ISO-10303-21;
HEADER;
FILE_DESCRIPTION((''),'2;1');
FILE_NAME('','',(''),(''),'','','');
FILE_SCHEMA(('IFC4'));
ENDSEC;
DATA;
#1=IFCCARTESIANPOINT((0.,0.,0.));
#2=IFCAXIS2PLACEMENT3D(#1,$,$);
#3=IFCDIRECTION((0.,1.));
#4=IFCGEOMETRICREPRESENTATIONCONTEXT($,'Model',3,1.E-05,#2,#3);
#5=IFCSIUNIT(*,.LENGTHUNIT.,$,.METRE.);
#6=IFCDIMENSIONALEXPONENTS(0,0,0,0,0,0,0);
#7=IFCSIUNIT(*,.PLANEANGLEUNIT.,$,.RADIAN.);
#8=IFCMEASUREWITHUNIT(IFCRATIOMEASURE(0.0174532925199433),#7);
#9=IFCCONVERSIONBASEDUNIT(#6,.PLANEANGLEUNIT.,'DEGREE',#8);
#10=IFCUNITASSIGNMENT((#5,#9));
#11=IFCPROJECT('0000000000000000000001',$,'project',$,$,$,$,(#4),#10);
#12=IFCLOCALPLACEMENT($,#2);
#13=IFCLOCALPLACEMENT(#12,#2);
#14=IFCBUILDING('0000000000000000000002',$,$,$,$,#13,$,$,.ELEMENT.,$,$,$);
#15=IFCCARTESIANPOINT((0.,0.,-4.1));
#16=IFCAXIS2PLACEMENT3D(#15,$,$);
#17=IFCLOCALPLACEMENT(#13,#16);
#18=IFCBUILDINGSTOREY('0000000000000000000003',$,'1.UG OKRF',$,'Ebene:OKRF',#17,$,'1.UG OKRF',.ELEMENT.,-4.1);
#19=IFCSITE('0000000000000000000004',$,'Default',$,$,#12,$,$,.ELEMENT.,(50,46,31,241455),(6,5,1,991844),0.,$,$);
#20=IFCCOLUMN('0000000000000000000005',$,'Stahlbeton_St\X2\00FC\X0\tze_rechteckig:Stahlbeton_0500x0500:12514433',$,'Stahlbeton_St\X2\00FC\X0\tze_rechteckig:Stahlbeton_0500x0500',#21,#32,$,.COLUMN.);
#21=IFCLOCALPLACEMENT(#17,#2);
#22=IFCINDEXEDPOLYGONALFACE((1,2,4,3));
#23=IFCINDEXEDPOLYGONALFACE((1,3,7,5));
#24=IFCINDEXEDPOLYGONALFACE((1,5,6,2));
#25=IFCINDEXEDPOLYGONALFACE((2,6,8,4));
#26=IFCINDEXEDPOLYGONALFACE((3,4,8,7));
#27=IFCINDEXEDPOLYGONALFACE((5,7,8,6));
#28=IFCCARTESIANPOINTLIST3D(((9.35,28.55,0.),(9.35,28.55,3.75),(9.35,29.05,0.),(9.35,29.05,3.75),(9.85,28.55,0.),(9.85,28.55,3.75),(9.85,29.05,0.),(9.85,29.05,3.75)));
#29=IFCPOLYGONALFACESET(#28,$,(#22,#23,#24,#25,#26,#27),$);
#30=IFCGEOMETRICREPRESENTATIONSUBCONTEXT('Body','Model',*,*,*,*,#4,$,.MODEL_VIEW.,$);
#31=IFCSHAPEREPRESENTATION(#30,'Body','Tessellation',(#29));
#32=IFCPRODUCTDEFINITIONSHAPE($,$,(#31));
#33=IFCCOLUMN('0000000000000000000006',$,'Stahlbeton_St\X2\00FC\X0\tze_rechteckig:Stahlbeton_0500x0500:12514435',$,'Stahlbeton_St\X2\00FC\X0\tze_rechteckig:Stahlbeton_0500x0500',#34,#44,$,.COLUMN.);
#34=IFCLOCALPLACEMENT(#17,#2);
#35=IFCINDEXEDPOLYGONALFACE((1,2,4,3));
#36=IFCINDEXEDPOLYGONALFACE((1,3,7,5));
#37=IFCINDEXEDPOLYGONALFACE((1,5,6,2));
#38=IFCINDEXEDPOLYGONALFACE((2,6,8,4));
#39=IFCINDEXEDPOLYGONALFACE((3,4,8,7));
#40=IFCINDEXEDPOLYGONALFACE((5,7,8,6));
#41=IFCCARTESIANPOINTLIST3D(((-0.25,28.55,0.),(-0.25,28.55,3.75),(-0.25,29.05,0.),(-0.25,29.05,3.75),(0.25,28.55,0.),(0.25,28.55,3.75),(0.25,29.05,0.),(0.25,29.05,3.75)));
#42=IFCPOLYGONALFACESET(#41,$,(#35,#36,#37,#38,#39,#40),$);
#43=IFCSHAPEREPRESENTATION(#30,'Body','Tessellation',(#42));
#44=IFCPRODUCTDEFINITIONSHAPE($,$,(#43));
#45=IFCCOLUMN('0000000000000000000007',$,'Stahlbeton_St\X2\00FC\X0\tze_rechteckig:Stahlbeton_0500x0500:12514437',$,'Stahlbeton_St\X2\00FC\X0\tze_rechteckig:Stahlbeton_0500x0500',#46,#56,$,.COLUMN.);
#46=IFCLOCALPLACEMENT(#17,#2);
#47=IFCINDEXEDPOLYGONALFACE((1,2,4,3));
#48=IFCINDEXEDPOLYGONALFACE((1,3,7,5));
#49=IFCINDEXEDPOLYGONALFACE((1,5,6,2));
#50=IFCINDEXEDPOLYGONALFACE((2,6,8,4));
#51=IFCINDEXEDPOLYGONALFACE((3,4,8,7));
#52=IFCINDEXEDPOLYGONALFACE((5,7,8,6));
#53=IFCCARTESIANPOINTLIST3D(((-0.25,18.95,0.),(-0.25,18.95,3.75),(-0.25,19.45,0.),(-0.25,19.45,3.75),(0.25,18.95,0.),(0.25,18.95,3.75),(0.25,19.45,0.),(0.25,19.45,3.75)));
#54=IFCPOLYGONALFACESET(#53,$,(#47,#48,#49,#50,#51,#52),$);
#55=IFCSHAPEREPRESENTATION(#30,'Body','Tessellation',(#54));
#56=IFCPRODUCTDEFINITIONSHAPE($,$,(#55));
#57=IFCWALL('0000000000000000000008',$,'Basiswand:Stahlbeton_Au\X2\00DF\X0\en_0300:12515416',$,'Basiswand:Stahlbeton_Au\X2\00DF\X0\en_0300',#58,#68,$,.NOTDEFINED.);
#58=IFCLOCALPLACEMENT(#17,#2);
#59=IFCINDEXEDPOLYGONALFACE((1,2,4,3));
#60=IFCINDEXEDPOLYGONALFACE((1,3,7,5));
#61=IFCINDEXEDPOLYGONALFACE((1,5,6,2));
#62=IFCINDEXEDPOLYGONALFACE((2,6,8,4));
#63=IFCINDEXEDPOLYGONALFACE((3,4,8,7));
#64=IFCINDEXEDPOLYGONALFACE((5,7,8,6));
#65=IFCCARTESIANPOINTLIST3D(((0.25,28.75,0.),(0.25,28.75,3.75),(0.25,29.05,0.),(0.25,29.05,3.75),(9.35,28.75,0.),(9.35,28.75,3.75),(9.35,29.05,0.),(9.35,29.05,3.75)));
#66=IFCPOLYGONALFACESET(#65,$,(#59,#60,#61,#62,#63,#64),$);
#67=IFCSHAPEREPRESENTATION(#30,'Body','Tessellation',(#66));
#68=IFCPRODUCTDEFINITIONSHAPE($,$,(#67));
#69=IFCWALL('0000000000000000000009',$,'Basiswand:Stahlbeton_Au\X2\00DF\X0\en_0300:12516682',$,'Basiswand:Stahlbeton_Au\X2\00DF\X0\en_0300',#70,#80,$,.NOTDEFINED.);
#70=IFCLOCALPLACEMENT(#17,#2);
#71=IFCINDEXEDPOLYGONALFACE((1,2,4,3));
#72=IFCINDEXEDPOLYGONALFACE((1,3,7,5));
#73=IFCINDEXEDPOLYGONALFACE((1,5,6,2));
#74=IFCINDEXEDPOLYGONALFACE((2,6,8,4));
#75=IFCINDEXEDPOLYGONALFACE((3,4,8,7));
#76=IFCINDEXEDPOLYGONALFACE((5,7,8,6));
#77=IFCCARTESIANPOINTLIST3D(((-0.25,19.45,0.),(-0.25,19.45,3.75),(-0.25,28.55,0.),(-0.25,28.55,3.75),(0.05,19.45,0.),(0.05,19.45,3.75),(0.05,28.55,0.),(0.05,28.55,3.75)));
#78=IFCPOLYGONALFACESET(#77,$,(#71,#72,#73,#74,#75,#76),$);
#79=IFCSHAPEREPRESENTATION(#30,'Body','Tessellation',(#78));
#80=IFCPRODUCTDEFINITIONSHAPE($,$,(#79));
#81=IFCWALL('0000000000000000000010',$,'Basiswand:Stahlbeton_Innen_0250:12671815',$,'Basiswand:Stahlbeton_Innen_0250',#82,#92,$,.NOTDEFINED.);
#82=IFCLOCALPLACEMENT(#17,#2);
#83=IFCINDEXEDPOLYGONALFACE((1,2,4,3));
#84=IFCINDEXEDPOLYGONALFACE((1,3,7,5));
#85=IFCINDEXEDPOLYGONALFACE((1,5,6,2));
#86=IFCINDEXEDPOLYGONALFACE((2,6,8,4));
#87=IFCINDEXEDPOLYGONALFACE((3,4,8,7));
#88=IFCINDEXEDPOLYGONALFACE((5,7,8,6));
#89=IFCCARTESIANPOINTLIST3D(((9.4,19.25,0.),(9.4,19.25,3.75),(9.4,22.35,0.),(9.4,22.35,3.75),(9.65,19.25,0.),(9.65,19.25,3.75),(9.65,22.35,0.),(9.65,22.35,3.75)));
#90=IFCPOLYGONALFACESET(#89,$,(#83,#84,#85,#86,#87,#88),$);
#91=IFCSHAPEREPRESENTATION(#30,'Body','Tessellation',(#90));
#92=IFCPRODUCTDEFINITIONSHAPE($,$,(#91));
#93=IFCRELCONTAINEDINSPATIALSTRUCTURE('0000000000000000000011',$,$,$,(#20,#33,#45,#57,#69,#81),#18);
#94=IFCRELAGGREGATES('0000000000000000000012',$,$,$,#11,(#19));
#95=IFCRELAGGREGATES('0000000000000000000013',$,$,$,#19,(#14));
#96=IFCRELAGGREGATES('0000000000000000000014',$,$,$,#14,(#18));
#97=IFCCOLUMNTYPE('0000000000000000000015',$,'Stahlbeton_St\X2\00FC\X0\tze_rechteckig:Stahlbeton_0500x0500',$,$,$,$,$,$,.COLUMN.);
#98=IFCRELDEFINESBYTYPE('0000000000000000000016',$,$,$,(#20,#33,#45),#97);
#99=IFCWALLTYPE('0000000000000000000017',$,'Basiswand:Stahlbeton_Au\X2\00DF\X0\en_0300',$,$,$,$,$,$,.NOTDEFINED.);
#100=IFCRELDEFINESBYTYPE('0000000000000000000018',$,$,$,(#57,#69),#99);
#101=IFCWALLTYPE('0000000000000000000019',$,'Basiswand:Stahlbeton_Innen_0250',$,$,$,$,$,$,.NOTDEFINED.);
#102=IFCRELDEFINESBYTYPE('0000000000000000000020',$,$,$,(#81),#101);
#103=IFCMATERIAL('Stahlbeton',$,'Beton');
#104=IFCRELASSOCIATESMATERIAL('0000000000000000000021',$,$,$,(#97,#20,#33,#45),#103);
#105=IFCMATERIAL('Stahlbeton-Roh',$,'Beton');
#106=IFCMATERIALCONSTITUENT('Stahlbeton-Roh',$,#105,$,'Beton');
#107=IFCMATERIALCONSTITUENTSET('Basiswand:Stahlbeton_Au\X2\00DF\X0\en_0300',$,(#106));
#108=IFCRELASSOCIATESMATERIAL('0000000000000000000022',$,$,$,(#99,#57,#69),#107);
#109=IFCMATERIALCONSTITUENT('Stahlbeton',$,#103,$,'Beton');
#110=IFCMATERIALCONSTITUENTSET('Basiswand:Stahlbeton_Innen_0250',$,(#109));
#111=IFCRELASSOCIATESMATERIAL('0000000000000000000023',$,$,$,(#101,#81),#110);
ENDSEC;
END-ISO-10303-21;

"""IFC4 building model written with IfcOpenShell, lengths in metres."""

from ifc_helpers import new_model, entity, si_unit, converted_unit, direction, frame, origin, place, context, subcontext, project, spatial, indexed_curve, outline, extrude, source, transform, mapped, material, constituent, constituent_set, type_object, type_shapes, element, save


model = new_model("IFC4")

# Units and contexts
model_context = context("Model", 3, precision=1e-05, world=origin(), true_north=direction((0.0, 1.0)))
body_context = subcontext(model_context, "Body", "Model", "MODEL_VIEW")
ifc_project = project(units=[si_unit("LENGTHUNIT", "METRE"), converted_unit("PLANEANGLEUNIT", "DEGREE", entity("IfcRatioMeasure", 0.0174532925199433), si_unit("PLANEANGLEUNIT", "RADIAN"), dimensions=[0, 0, 0, 0, 0, 0, 0])], contexts=[model_context])

# Site, building, storey
site_placement = place(None, origin())
site = spatial("IfcSite", under=ifc_project, at=site_placement, Name="Default", CompositionType="ELEMENT", RefLatitude=(50, 46, 31, 241455), RefLongitude=(6, 5, 1, 991844), RefElevation=0.0)
building_placement = place(site_placement, origin())
building = spatial("IfcBuilding", under=site, at=building_placement, CompositionType="ELEMENT")
storey_placement = place(building_placement, frame((0.0, 0.0, -4.1)))
storey = spatial("IfcBuildingStorey", under=building, at=storey_placement, Name="1.UG OKRF", ObjectType="Ebene:OKRF", LongName="1.UG OKRF", CompositionType="ELEMENT", Elevation=-4.1)

# Columns
ifc_material_1 = material(Name="Stahlbeton", Category="Beton")
column_type = type_object("IfcColumnType", Name="Stahlbeton_Stütze_rechteckig:Stahlbeton_0500x0500", PredefinedType="COLUMN", material=ifc_material_1)
shared_shape = source(origin(), body_context, "Body", "SweptSolid", [
    extrude(outline(indexed_curve([(-0.25, -0.25), (0.25, -0.25), (0.25, 0.25), (-0.25, 0.25), (-0.25, -0.25)], self_intersect=False)), frame((0.0, 0.0, -4.1), z_axis=(0.0, 0.0, 1.0), x_axis=(0.0, -1.0, 0.0)), (0.0, 0.0, 1.0), 3.75),
])
type_shapes(column_type, [shared_shape])
for number, where, name in (
    (1, (9.6, 28.8, 4.1), "Stahlbeton_Stütze_rechteckig:Stahlbeton_0500x0500:12514433"),
    (2, (0.0, 28.8, 4.1), "Stahlbeton_Stütze_rechteckig:Stahlbeton_0500x0500:12514435"),
    (3, (0.0, 19.2, 4.1), "Stahlbeton_Stütze_rechteckig:Stahlbeton_0500x0500:12514437"),
):
    element("IfcColumn", number, at=place(storey_placement, frame(where)), inside=storey, type_object=column_type, material=ifc_material_1, Name=name, ObjectType="Stahlbeton_Stütze_rechteckig:Stahlbeton_0500x0500", PredefinedType="COLUMN", context=body_context, shape_type="MappedRepresentation", body=[
        mapped(shared_shape, transform((0.0, 0.0, 0.0), scale=1.0)),
    ])

# Walls
ifc_material_2 = material(Name="Stahlbeton-Roh", Category="Beton")
ifc_constituent_1 = constituent(ifc_material_2, Name="Stahlbeton-Roh", Category="Beton")
ifc_constituent_set_1 = constituent_set(constituents=[ifc_constituent_1], Name="Basiswand:Stahlbeton_Außen_0300")
wall_type_1 = type_object("IfcWallType", Name="Basiswand:Stahlbeton_Außen_0300", PredefinedType="NOTDEFINED", material=ifc_constituent_set_1)
wall_1_placement = place(storey_placement, frame((0.25, 28.9, 0.0)))
element("IfcWall", 4, at=wall_1_placement, inside=storey, type_object=wall_type_1, material=ifc_constituent_set_1, Name="Basiswand:Stahlbeton_Außen_0300:12515416", ObjectType="Basiswand:Stahlbeton_Außen_0300", PredefinedType="NOTDEFINED", context=body_context, shape_type="SweptSolid", body=[
    extrude(outline(indexed_curve([(-0.15, -4.55), (0.15, -4.55), (0.15, 4.55), (-0.15, 4.55), (-0.15, -4.55)], self_intersect=False)), frame((4.55, 0.0, 0.0), z_axis=(0.0, 0.0, 1.0), x_axis=(0.0, 1.0, 0.0)), (0.0, 0.0, 1.0), 3.75),
])
wall_2_placement = place(storey_placement, frame((-0.1, 19.45, 0.0), z_axis=(0.0, 0.0, 1.0), x_axis=(0.0, 1.0, 0.0)))
element("IfcWall", 5, at=wall_2_placement, inside=storey, type_object=wall_type_1, material=ifc_constituent_set_1, Name="Basiswand:Stahlbeton_Außen_0300:12516682", ObjectType="Basiswand:Stahlbeton_Außen_0300", PredefinedType="NOTDEFINED", context=body_context, shape_type="SweptSolid", body=[
    extrude(outline(indexed_curve([(-0.15, -4.55), (0.15, -4.55), (0.15, 4.55), (-0.15, 4.55), (-0.15, -4.55)], self_intersect=False)), frame((4.55, 0.0, 0.0), z_axis=(0.0, 0.0, 1.0), x_axis=(0.0, 1.0, 0.0)), (0.0, 0.0, 1.0), 3.75),
])

# Shared definitions
ifc_constituent_2 = constituent(ifc_material_1, Name="Stahlbeton", Category="Beton")
ifc_constituent_set_2 = constituent_set(constituents=[ifc_constituent_2], Name="Basiswand:Stahlbeton_Innen_0250")
wall_type_2 = type_object("IfcWallType", Name="Basiswand:Stahlbeton_Innen_0250", PredefinedType="NOTDEFINED", material=ifc_constituent_set_2)

# Wall
wall_3_placement = place(storey_placement, frame((9.525, 22.35, 0.0), z_axis=(0.0, 0.0, 1.0), x_axis=(0.0, -1.0, 0.0)))
element("IfcWall", 6, at=wall_3_placement, inside=storey, type_object=wall_type_2, material=ifc_constituent_set_2, Name="Basiswand:Stahlbeton_Innen_0250:12671815", ObjectType="Basiswand:Stahlbeton_Innen_0250", PredefinedType="NOTDEFINED", context=body_context, shape_type="SweptSolid", body=[
    extrude(outline(indexed_curve([(-0.125, -1.55), (0.125, -1.55), (0.125, 1.55), (-0.125, 1.55), (-0.125, -1.55)], self_intersect=False)), frame((1.55, 0.0, 0.0), z_axis=(0.0, 0.0, 1.0), x_axis=(0.0, 1.0, 0.0)), (0.0, 0.0, 1.0), 3.75),
])

save(model, "model.ifc")
